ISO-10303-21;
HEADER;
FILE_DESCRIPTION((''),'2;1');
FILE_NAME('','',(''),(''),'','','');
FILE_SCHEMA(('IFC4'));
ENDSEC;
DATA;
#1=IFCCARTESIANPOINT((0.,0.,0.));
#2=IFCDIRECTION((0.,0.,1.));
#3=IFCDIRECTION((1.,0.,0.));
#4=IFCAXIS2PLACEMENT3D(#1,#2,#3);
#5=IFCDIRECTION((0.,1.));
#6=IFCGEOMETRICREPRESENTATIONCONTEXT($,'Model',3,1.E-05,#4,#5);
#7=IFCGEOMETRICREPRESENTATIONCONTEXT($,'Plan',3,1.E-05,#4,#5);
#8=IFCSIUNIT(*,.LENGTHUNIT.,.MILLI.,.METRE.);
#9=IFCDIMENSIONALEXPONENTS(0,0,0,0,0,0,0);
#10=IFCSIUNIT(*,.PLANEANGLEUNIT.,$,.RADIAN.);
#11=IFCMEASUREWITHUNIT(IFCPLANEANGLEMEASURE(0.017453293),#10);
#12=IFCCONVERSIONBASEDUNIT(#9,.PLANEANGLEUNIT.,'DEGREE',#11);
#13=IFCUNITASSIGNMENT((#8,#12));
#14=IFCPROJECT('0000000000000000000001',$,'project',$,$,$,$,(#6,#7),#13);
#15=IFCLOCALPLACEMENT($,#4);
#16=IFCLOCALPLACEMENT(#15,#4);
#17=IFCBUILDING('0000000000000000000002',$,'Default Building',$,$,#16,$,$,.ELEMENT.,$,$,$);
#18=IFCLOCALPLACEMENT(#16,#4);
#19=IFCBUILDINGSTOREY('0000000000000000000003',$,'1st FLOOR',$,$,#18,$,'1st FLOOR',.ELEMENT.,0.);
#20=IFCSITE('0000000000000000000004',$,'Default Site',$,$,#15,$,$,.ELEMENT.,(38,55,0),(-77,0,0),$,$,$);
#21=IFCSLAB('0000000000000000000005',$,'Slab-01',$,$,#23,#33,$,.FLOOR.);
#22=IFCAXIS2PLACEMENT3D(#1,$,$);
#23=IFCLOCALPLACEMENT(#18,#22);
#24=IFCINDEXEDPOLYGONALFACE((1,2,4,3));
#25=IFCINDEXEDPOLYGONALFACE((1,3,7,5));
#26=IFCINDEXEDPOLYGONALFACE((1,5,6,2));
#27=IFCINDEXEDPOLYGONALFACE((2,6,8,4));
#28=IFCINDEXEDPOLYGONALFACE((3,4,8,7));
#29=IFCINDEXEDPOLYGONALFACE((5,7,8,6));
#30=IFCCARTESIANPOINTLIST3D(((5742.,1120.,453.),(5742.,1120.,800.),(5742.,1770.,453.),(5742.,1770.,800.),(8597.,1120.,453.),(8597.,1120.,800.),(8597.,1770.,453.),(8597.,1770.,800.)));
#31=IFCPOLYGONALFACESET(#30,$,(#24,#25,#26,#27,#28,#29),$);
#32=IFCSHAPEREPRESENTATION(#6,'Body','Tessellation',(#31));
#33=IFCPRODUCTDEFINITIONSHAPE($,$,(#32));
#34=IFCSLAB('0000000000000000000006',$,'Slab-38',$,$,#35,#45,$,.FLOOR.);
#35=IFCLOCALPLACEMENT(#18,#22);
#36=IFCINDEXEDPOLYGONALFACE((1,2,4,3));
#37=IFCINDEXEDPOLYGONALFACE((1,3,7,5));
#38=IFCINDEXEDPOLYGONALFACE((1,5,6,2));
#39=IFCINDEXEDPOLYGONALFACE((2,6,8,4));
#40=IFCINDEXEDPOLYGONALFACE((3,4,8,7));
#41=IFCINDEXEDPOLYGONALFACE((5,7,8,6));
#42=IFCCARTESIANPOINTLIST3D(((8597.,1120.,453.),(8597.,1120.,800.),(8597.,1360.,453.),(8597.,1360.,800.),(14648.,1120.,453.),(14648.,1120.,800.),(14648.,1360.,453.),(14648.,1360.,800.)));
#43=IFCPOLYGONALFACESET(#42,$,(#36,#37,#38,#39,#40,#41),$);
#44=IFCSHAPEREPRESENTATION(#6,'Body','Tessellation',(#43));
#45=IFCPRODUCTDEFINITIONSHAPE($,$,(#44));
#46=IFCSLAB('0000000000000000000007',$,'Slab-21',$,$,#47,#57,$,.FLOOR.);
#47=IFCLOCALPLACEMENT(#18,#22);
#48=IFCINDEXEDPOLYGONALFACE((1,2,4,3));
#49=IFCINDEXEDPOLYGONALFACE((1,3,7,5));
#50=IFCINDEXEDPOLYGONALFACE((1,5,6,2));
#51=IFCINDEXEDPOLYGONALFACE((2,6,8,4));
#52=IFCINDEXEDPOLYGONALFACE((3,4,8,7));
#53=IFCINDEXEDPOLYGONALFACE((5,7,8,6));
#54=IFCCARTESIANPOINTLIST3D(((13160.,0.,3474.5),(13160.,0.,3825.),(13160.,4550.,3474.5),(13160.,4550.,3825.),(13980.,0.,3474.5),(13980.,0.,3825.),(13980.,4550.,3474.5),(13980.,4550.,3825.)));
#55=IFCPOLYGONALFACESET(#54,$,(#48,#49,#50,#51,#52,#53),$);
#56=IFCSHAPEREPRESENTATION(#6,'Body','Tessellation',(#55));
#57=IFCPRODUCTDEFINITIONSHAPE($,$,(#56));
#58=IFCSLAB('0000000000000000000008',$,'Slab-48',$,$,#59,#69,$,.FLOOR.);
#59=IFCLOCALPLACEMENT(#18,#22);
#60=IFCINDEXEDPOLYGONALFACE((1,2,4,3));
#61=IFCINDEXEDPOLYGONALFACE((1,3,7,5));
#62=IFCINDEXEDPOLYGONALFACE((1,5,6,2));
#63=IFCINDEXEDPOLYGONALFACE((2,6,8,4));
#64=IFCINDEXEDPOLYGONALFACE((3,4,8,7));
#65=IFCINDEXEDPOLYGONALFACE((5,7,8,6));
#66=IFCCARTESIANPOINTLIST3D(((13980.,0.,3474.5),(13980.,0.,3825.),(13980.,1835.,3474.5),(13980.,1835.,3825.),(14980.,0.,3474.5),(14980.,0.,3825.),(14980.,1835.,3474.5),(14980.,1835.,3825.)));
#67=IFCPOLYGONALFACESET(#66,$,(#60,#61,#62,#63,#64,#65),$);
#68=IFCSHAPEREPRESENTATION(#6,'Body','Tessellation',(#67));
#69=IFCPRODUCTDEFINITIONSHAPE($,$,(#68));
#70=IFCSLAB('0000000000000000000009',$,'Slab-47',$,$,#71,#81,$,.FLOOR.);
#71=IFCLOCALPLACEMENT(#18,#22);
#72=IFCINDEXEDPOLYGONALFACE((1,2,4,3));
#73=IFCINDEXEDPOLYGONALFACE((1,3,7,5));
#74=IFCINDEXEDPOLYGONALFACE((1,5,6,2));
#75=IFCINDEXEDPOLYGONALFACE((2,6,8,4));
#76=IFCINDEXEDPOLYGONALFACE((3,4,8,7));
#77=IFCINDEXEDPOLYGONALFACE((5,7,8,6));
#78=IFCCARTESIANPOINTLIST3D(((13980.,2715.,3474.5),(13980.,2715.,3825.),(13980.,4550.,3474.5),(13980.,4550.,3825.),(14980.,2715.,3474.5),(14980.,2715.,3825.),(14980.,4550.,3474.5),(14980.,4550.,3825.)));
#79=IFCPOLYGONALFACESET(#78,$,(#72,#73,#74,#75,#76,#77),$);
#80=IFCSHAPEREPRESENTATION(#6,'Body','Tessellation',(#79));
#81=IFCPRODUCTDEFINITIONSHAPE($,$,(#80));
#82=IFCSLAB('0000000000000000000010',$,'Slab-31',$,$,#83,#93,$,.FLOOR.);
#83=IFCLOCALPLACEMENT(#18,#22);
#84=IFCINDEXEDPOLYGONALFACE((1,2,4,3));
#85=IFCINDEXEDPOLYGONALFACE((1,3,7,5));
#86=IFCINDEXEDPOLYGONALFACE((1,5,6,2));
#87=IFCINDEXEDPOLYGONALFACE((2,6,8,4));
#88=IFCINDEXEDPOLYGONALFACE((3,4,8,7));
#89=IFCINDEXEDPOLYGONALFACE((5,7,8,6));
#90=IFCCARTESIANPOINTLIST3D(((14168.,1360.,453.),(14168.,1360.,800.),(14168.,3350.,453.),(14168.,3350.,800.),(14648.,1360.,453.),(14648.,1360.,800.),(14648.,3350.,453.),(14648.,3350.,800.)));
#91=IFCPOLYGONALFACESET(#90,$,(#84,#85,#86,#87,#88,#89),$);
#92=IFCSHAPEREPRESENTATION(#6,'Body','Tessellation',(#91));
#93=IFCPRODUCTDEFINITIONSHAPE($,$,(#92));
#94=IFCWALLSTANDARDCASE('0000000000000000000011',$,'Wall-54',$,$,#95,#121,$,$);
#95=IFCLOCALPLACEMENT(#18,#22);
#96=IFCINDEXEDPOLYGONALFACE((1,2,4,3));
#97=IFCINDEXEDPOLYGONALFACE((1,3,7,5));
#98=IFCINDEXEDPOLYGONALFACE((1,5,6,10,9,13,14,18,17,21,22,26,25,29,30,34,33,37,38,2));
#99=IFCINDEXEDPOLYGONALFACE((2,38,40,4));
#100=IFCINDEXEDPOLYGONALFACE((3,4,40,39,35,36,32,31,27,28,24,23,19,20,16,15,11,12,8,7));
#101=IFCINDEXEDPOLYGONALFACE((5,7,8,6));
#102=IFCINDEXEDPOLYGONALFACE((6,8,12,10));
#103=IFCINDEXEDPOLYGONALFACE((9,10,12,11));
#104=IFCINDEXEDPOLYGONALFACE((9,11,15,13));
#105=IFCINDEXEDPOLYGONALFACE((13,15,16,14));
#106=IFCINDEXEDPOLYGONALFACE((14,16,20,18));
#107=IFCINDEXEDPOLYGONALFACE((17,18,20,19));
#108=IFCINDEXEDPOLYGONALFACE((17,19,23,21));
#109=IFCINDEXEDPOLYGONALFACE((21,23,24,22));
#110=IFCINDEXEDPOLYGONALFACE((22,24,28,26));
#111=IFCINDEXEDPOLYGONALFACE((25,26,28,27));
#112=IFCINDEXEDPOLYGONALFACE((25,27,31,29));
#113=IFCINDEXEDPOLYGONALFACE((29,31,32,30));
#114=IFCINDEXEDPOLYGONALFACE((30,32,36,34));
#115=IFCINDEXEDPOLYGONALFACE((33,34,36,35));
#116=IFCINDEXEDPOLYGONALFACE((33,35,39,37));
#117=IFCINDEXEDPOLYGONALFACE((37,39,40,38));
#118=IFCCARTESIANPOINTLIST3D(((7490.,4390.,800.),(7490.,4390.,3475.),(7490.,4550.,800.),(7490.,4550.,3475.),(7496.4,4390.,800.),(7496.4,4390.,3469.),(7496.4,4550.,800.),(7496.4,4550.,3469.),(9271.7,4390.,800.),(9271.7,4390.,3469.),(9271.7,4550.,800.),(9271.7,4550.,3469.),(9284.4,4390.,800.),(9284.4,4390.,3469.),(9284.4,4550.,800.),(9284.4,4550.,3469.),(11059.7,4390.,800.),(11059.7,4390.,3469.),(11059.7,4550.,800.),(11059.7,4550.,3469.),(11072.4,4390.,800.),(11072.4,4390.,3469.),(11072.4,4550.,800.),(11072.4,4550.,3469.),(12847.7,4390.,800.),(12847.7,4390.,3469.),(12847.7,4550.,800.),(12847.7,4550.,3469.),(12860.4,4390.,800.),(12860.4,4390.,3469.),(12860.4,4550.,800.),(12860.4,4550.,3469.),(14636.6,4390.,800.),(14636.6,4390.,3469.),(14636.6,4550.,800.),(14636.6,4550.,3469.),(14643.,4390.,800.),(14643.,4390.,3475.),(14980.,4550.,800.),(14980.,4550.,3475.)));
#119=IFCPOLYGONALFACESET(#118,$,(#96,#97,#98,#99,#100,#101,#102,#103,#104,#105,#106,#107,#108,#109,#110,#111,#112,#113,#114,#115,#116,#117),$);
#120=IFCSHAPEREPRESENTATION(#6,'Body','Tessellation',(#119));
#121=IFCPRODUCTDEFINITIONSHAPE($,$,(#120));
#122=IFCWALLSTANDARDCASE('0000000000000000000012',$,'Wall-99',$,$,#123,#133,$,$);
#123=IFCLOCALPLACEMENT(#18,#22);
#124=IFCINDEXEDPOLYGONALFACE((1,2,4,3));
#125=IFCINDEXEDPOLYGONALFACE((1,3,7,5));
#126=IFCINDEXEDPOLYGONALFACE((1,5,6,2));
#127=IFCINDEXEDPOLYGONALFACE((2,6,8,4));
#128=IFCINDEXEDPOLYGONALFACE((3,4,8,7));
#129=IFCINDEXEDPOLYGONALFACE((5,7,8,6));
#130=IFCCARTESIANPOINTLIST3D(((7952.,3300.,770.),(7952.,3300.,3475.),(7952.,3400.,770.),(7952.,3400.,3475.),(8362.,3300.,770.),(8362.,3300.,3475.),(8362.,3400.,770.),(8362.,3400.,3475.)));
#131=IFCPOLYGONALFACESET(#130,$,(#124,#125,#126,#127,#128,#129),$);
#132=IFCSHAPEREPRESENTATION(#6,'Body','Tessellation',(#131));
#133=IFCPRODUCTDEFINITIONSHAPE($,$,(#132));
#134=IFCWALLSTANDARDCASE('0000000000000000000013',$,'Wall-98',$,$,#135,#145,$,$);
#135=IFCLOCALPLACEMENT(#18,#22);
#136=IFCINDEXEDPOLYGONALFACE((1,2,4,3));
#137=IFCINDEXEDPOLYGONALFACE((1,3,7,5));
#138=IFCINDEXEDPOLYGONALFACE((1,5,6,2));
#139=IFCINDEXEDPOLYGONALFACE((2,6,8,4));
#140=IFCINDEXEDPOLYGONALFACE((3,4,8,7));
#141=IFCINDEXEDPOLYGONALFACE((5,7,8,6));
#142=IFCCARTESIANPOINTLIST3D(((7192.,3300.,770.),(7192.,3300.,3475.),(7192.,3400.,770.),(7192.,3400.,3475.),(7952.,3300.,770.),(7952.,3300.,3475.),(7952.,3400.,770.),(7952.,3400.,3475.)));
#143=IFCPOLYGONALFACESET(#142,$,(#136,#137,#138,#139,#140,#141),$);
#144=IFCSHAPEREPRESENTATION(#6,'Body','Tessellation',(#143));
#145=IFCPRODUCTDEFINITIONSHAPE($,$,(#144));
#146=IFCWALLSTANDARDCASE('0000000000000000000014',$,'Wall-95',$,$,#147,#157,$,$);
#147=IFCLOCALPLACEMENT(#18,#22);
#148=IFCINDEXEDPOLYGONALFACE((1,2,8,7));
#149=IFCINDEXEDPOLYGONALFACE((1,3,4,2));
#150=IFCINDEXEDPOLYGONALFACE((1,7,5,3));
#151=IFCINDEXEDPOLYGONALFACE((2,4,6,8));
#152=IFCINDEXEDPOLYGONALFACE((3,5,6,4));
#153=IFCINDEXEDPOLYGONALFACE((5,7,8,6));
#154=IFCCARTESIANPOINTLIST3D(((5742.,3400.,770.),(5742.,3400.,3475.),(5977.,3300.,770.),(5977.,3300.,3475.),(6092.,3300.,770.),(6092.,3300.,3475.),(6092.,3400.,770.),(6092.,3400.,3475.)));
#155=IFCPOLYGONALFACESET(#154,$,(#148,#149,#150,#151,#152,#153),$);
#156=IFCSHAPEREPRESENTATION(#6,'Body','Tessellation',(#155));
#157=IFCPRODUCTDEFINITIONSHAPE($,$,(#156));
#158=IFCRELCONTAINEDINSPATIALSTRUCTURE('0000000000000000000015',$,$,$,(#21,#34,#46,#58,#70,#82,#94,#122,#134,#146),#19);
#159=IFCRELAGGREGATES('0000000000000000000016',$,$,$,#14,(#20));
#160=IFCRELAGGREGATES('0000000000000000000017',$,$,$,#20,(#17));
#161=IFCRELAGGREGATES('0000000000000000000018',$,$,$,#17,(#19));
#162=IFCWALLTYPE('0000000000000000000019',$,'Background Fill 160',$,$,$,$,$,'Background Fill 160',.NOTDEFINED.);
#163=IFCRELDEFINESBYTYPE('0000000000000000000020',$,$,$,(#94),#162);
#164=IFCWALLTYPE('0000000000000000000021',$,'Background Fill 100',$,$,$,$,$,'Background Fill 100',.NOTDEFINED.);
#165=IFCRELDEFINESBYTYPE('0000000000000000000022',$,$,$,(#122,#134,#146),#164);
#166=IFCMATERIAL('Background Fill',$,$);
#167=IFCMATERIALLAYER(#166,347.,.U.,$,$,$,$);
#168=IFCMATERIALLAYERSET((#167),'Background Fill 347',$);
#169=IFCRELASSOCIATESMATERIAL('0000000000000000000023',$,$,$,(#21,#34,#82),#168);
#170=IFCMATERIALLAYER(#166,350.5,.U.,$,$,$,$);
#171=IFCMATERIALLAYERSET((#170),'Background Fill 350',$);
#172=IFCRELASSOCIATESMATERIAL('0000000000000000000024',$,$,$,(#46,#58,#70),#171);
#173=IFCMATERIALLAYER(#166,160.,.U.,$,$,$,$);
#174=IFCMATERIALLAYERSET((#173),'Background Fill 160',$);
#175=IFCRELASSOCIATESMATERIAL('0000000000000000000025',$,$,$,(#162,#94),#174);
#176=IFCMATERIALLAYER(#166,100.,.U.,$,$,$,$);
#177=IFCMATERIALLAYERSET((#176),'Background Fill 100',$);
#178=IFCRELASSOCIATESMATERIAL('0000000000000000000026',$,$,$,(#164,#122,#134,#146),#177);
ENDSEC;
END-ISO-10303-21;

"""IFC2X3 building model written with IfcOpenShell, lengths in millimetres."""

from ifc_helpers import new_model, entity, si_unit, converted_unit, direction, frame, origin_with_axes, place, context, project, spatial, polyline, outline, extrude, material, layer, layer_set, layer_usage, type_object, element, save


model = new_model("IFC2X3")

# Units and contexts
model_context = context("Model", 3, precision=1e-05, world=origin_with_axes(), true_north=direction((0.0, 1.0)))
plan_context = context("Plan", 3, precision=1e-05, world=origin_with_axes(), true_north=direction((0.0, 1.0)))
ifc_project = project(units=[si_unit("LENGTHUNIT", "METRE", prefix="MILLI"), converted_unit("PLANEANGLEUNIT", "DEGREE", entity("IfcPlaneAngleMeasure", 0.017453293), si_unit("PLANEANGLEUNIT", "RADIAN"), dimensions=[0, 0, 0, 0, 0, 0, 0])], contexts=[model_context, plan_context])

# Site, building, storey
site_placement = place(None, origin_with_axes())
site = spatial("IfcSite", under=ifc_project, at=site_placement, Name="Default Site", CompositionType="ELEMENT", RefLatitude=(38, 55, 0), RefLongitude=(-77, 0, 0))
building_placement = place(site_placement, origin_with_axes())
building = spatial("IfcBuilding", under=site, at=building_placement, Name="Default Building", CompositionType="ELEMENT")
storey_placement = place(building_placement, origin_with_axes())
storey = spatial("IfcBuildingStorey", under=building, at=storey_placement, Name="1st FLOOR", LongName="1st FLOOR", CompositionType="ELEMENT", Elevation=0.0)

# Slabs
ifc_material = material(Name="Background Fill")
ifc_layer_1 = layer(ifc_material, 347.0, ventilated="UNKNOWN")
ifc_layer_set_1 = layer_set([ifc_layer_1], Name="Background Fill 347")
ifc_layer_2 = layer(ifc_material, 350.5, ventilated="UNKNOWN")
ifc_layer_set_2 = layer_set([ifc_layer_2], Name="Background Fill 350")
ifc_layer_usage_1 = layer_usage(ifc_layer_set_1, "AXIS3", "NEGATIVE", 347.0)
slab_1_placement = place(storey_placement, frame((5742.0, 1120.0, 453.0), z_axis=(0.0, 0.0, 1.0), x_axis=(1.0, 0.0, 0.0)))
element("IfcSlab", 1, at=slab_1_placement, inside=storey, material=ifc_layer_usage_1, Name="Slab-01", PredefinedType="FLOOR", context=model_context, shape_type="SweptSolid", body=[
    extrude(outline(polyline([(0.0, 0.0), (2855.0, 0.0), (2855.0, 650.0), (0.0, 650.0), (0.0, 0.0)])), origin_with_axes(), (0.0, 0.0, 1.0), 347.0),
])
ifc_layer_usage_2 = layer_usage(ifc_layer_set_1, "AXIS3", "NEGATIVE", 347.0)
slab_2_placement = place(storey_placement, frame((8597.0, 1120.0, 453.0), z_axis=(0.0, 0.0, 1.0), x_axis=(1.0, 0.0, 0.0)))
element("IfcSlab", 2, at=slab_2_placement, inside=storey, material=ifc_layer_usage_2, Name="Slab-38", PredefinedType="FLOOR", context=model_context, shape_type="SweptSolid", body=[
    extrude(outline(polyline([(0.0, 0.0), (6051.0, 0.0), (6051.0, 240.0), (0.0, 240.0), (0.0, 0.0)])), origin_with_axes(), (0.0, 0.0, 1.0), 347.0),
])
ifc_layer_usage_3 = layer_usage(ifc_layer_set_2, "AXIS3", "NEGATIVE", 350.5)
slab_3_placement = place(storey_placement, frame((13980.0, 0.0, 3474.5), z_axis=(0.0, 0.0, 1.0), x_axis=(-1.0, 0.0, 0.0)))
element("IfcSlab", 3, at=slab_3_placement, inside=storey, material=ifc_layer_usage_3, Name="Slab-21", PredefinedType="FLOOR", context=model_context, shape_type="SweptSolid", body=[
    extrude(outline(polyline([(0.0, 0.0), (820.0, 0.0), (820.0, -4550.0), (0.0, -4550.0), (0.0, 0.0)])), origin_with_axes(), (0.0, 0.0, 1.0), 350.5),
])
ifc_layer_usage_4 = layer_usage(ifc_layer_set_2, "AXIS3", "NEGATIVE", 350.5)
slab_4_placement = place(storey_placement, frame((14980.0, 0.0, 3474.5), z_axis=(0.0, 0.0, 1.0), x_axis=(-1.0, 0.0, 0.0)))
element("IfcSlab", 4, at=slab_4_placement, inside=storey, material=ifc_layer_usage_4, Name="Slab-48", PredefinedType="FLOOR", context=model_context, shape_type="SweptSolid", body=[
    extrude(outline(polyline([(0.0, 0.0), (1000.0, 0.0), (1000.0, -1835.0), (0.0, -1835.0), (0.0, 0.0)])), origin_with_axes(), (0.0, 0.0, 1.0), 350.5),
])
ifc_layer_usage_5 = layer_usage(ifc_layer_set_2, "AXIS3", "NEGATIVE", 350.5)
slab_5_placement = place(storey_placement, frame((14980.0, 4550.0, 3474.5), z_axis=(0.0, 0.0, 1.0), x_axis=(-1.0, 0.0, 0.0)))
element("IfcSlab", 5, at=slab_5_placement, inside=storey, material=ifc_layer_usage_5, Name="Slab-47", PredefinedType="FLOOR", context=model_context, shape_type="SweptSolid", body=[
    extrude(outline(polyline([(0.0, 0.0), (1000.0, 0.0), (1000.0, 1835.0), (0.0, 1835.0), (0.0, 0.0)])), origin_with_axes(), (0.0, 0.0, 1.0), 350.5),
])
ifc_layer_usage_6 = layer_usage(ifc_layer_set_1, "AXIS3", "NEGATIVE", 347.0)
slab_6_placement = place(storey_placement, frame((14648.0, 1360.0, 453.0), z_axis=(0.0, 0.0, 1.0), x_axis=(-1.0, 0.0, 0.0)))
element("IfcSlab", 6, at=slab_6_placement, inside=storey, material=ifc_layer_usage_6, Name="Slab-31", PredefinedType="FLOOR", context=model_context, shape_type="SweptSolid", body=[
    extrude(outline(polyline([(0.0, 0.0), (480.0, 0.0), (480.0, -1990.0), (0.0, -1990.0), (0.0, 0.0)])), origin_with_axes(), (0.0, 0.0, 1.0), 347.0),
])

# Wall, openings
ifc_layer_3 = layer(ifc_material, 160.0, ventilated="UNKNOWN")
ifc_layer_set_3 = layer_set([ifc_layer_3], Name="Background Fill 160")
ifc_layer_usage_7 = layer_usage(ifc_layer_set_3, "AXIS2", "NEGATIVE", 0.0)
wall_type_1 = type_object("IfcWallType", Name="Background Fill 160", ElementType="Background Fill 160", PredefinedType="NOTDEFINED", material=ifc_layer_set_3)
wall_1_placement = place(storey_placement, frame((7490.0, 4550.0, 800.0), z_axis=(0.0, 0.0, 1.0), x_axis=(1.0, 0.0, 0.0)))
wall_1 = element("IfcWallStandardCase", 7, at=wall_1_placement, inside=storey, type_object=wall_type_1, material=ifc_layer_usage_7, Name="Wall-54", context=model_context, shape_type="SweptSolid", body=[
    extrude(outline(polyline([(0.0, -160.0), (7153.0, -160.0), (7490.0, 0.0), (0.0, 0.0), (0.0, -160.0)])), origin_with_axes(), (0.0, 0.0, 1.0), 2675.0),
])
opening_1_placement = place(wall_1_placement, frame((894.0, -160.0, 0.0), z_axis=(0.0, 0.0, 1.0), x_axis=(1.0, 0.0, 0.0)))
element("IfcOpeningElement", 8, at=opening_1_placement, cuts=wall_1, ObjectType="Opening", context=model_context, shape_type="SweptSolid", body=[
    extrude(outline(polyline([(-887.6, 0.0), (887.6, 0.0), (887.6, 2669.0), (-887.6, 2669.0), (-887.6, 0.0)])), frame((0.0, 0.0, 0.0), z_axis=(0.0, 1.0, 0.0), x_axis=(-1.0, 0.0, 0.0)), (0.0, 0.0, 1.0), 160.0),
])
opening_2_placement = place(wall_1_placement, frame((2682.0, -160.0, 0.0), z_axis=(0.0, 0.0, 1.0), x_axis=(1.0, 0.0, 0.0)))
element("IfcOpeningElement", 9, at=opening_2_placement, cuts=wall_1, ObjectType="Opening", context=model_context, shape_type="SweptSolid", body=[
    extrude(outline(polyline([(-887.6, 0.0), (887.6, 0.0), (887.6, 2669.0), (-887.6, 2669.0), (-887.6, 0.0)])), frame((0.0, 0.0, 0.0), z_axis=(0.0, 1.0, 0.0), x_axis=(-1.0, 0.0, 0.0)), (0.0, 0.0, 1.0), 160.0),
])
opening_3_placement = place(wall_1_placement, frame((4470.0, -160.0, 0.0), z_axis=(0.0, 0.0, 1.0), x_axis=(1.0, 0.0, 0.0)))
element("IfcOpeningElement", 10, at=opening_3_placement, cuts=wall_1, ObjectType="Opening", context=model_context, shape_type="SweptSolid", body=[
    extrude(outline(polyline([(-887.6, 0.0), (887.6, 0.0), (887.6, 2669.0), (-887.6, 2669.0), (-887.6, 0.0)])), frame((0.0, 0.0, 0.0), z_axis=(0.0, 1.0, 0.0), x_axis=(-1.0, 0.0, 0.0)), (0.0, 0.0, 1.0), 160.0),
])
opening_4_placement = place(wall_1_placement, frame((6258.5, -160.0, 0.0), z_axis=(0.0, 0.0, 1.0), x_axis=(1.0, 0.0, 0.0)))
element("IfcOpeningElement", 11, at=opening_4_placement, cuts=wall_1, ObjectType="Opening", context=model_context, shape_type="SweptSolid", body=[
    extrude(outline(polyline([(-888.1, 0.0), (888.1, 0.0), (888.1, 2669.0), (-888.1, 2669.0), (-888.1, 0.0)])), frame((0.0, 0.0, 0.0), z_axis=(0.0, 1.0, 0.0), x_axis=(-1.0, 0.0, 0.0)), (0.0, 0.0, 1.0), 160.0),
])

# Walls
ifc_layer_4 = layer(ifc_material, 100.0, ventilated="UNKNOWN")
ifc_layer_set_4 = layer_set([ifc_layer_4], Name="Background Fill 100")
ifc_layer_usage_8 = layer_usage(ifc_layer_set_4, "AXIS2", "NEGATIVE", 0.0)
wall_type_2 = type_object("IfcWallType", Name="Background Fill 100", ElementType="Background Fill 100", PredefinedType="NOTDEFINED", material=ifc_layer_set_4)
wall_2_placement = place(storey_placement, frame((7952.0, 3400.0, 770.0), z_axis=(0.0, 0.0, 1.0), x_axis=(1.0, 0.0, 0.0)))
element("IfcWallStandardCase", 12, at=wall_2_placement, inside=storey, type_object=wall_type_2, material=ifc_layer_usage_8, Name="Wall-99", context=model_context, shape_type="SweptSolid", body=[
    extrude(outline(polyline([(0.0, -100.0), (410.0, -100.0), (410.0, 0.0), (0.0, 0.0), (0.0, -100.0)])), origin_with_axes(), (0.0, 0.0, 1.0), 2705.0),
])
ifc_layer_usage_9 = layer_usage(ifc_layer_set_4, "AXIS2", "NEGATIVE", 0.0)
wall_3_placement = place(storey_placement, frame((7192.0, 3400.0, 770.0), z_axis=(0.0, 0.0, 1.0), x_axis=(1.0, 0.0, 0.0)))
element("IfcWallStandardCase", 13, at=wall_3_placement, inside=storey, type_object=wall_type_2, material=ifc_layer_usage_9, Name="Wall-98", context=model_context, shape_type="SweptSolid", body=[
    extrude(outline(polyline([(0.0, -100.0), (760.0, -100.0), (760.0, 0.0), (0.0, 0.0), (0.0, -100.0)])), origin_with_axes(), (0.0, 0.0, 1.0), 2705.0),
])
ifc_layer_usage_10 = layer_usage(ifc_layer_set_4, "AXIS2", "NEGATIVE", 0.0)
wall_4_placement = place(storey_placement, frame((5742.0, 3400.0, 770.0), z_axis=(0.0, 0.0, 1.0), x_axis=(1.0, 0.0, 0.0)))
element("IfcWallStandardCase", 14, at=wall_4_placement, inside=storey, type_object=wall_type_2, material=ifc_layer_usage_10, Name="Wall-95", context=model_context, shape_type="SweptSolid", body=[
    extrude(outline(polyline([(235.0, -100.0), (350.0, -100.0), (350.0, 0.0), (0.0, 0.0), (235.0, -100.0)])), origin_with_axes(), (0.0, 0.0, 1.0), 2705.0),
])

save(model, "model.ifc")
